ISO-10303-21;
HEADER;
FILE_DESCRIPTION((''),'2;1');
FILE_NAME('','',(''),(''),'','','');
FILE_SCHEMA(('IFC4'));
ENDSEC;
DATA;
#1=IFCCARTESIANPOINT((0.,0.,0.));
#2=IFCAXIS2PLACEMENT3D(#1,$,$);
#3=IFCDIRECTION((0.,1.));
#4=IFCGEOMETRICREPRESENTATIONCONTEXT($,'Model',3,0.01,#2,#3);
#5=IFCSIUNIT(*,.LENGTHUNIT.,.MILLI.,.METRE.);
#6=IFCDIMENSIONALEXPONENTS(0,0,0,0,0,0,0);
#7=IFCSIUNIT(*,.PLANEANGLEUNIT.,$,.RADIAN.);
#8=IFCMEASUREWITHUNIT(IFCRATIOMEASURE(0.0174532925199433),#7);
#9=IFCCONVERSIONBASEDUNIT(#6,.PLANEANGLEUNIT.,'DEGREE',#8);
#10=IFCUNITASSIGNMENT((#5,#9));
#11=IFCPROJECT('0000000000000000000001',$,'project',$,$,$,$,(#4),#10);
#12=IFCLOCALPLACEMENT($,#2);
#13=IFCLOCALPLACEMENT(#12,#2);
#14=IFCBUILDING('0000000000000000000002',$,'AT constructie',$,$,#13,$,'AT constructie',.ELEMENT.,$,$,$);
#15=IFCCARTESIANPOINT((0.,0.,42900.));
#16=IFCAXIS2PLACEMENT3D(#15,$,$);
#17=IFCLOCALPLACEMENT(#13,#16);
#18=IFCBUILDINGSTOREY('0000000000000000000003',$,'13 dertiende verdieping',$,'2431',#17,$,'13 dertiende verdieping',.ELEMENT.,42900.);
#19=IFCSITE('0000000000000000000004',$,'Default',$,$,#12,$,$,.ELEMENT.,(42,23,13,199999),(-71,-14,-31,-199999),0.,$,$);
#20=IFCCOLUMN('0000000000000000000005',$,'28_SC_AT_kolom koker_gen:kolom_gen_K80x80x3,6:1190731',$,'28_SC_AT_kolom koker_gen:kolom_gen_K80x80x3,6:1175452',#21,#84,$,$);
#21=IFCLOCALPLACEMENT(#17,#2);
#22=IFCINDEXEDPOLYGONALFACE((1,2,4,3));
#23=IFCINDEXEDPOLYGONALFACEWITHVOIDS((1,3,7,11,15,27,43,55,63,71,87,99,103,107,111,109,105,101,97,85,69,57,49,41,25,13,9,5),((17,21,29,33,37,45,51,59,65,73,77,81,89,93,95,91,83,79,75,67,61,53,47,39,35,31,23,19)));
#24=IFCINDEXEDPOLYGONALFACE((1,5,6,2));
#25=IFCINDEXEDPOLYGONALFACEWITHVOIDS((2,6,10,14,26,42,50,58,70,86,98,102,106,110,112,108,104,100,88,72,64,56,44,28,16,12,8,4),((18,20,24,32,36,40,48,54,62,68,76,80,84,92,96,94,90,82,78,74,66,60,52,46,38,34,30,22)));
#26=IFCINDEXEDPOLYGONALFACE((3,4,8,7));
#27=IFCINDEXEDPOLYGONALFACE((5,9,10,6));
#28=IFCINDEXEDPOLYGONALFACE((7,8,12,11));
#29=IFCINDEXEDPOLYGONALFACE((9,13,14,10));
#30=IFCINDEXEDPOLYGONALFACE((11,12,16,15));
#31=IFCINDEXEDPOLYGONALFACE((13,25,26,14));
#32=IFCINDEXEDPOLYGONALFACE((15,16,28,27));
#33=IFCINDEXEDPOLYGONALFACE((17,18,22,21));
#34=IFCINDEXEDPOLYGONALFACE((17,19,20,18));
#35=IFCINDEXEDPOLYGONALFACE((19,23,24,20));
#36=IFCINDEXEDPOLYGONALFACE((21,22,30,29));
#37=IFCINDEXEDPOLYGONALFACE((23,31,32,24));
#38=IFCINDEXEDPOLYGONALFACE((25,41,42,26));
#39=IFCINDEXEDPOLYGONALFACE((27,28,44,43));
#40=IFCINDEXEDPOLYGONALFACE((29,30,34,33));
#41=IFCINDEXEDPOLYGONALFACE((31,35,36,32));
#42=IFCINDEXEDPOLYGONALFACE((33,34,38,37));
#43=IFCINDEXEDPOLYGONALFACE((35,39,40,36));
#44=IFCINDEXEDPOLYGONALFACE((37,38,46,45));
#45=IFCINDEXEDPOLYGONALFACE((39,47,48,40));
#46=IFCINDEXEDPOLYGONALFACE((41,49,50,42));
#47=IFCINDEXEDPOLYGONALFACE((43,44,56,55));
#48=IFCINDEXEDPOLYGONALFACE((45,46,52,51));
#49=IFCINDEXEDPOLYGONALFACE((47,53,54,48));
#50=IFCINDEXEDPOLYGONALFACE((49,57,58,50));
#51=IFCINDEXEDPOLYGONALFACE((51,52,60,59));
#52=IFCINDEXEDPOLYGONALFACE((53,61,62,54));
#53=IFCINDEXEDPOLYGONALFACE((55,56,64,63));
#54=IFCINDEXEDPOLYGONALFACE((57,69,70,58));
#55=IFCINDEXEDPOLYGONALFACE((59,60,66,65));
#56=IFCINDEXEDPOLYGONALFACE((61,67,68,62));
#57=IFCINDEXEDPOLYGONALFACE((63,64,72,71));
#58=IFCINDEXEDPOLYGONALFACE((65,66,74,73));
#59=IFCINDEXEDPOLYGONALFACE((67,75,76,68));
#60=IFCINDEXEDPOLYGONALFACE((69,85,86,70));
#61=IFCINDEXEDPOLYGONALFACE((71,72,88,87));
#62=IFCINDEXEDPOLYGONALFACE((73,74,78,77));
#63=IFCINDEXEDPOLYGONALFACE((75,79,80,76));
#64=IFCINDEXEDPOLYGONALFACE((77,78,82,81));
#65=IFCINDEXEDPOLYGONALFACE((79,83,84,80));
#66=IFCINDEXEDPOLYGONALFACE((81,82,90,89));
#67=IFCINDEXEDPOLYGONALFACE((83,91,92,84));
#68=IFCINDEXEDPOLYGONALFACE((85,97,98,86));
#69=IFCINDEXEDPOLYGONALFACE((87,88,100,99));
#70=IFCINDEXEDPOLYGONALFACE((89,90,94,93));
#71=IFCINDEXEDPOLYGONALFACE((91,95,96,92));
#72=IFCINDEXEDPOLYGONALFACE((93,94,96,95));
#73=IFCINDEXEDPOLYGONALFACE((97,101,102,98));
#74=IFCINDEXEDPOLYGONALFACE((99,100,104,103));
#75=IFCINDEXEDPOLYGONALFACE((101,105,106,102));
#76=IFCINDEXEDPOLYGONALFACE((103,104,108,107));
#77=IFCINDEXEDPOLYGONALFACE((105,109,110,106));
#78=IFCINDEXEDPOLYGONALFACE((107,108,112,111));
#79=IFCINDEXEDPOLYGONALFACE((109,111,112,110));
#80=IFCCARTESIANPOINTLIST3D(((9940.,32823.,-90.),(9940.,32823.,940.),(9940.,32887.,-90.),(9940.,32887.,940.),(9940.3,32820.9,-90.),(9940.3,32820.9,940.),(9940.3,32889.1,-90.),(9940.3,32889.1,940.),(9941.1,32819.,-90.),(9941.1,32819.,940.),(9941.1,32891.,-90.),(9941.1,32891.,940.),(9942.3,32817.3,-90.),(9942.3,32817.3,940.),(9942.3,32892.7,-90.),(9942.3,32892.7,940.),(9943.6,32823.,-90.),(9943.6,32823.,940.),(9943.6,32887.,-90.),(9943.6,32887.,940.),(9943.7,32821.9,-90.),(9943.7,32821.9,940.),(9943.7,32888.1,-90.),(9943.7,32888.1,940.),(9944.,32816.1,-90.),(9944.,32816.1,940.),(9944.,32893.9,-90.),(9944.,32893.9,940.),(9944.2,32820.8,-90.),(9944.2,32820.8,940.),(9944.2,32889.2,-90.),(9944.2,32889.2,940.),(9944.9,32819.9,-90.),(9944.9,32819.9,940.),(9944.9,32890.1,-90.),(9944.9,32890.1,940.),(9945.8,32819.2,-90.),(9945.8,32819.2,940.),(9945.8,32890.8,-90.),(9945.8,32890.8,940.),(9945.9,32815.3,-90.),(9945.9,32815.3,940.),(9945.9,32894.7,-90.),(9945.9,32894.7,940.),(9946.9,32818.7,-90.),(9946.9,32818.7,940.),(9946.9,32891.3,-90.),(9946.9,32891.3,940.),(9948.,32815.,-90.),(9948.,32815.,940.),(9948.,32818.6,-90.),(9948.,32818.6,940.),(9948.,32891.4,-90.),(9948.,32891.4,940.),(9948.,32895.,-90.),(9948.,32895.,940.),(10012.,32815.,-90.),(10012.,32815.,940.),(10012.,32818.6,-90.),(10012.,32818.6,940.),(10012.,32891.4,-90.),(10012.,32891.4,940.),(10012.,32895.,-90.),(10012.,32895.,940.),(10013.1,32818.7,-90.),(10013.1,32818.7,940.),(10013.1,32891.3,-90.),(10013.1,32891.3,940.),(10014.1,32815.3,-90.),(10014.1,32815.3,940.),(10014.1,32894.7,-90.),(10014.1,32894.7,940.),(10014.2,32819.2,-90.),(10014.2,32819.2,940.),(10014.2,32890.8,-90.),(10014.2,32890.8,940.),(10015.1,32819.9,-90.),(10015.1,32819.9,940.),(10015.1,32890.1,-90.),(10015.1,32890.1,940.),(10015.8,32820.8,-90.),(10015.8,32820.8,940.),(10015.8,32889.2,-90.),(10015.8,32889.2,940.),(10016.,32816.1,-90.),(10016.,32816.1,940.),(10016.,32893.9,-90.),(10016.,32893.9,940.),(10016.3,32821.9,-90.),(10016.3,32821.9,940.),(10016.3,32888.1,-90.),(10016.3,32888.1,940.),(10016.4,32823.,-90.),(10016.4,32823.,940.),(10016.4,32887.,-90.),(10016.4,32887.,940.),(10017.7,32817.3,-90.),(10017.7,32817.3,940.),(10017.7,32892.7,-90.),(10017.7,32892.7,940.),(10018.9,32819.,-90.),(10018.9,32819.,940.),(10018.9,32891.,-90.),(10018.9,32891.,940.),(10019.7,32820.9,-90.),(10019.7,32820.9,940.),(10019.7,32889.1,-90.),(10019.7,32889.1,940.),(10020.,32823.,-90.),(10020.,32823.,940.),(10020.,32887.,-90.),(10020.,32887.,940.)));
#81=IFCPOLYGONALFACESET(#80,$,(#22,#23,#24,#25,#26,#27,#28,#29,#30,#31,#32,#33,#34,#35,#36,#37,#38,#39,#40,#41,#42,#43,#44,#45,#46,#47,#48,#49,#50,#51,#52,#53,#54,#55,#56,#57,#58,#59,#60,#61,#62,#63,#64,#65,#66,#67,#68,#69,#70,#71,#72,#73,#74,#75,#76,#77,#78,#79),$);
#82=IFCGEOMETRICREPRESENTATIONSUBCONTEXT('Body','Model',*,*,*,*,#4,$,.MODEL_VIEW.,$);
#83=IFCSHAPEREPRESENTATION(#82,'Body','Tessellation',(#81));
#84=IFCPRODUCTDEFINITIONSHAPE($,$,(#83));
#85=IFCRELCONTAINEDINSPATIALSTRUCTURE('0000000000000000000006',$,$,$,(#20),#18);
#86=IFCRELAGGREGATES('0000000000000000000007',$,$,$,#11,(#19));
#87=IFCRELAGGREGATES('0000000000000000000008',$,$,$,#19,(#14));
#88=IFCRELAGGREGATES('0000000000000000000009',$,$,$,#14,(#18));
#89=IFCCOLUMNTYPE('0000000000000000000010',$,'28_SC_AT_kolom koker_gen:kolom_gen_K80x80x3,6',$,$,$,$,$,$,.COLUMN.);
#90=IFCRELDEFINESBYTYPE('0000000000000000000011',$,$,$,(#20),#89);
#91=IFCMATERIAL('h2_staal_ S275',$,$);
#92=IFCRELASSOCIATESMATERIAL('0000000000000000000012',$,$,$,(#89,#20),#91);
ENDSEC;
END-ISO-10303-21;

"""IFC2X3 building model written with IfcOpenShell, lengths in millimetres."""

from ifc_helpers import new_model, entity, si_unit, converted_unit, direction, frame, frame_2d, origin, place, context, subcontext, project, spatial, polyline, circle_curve, parameter, trimmed, segment, composite_curve, outline, extrude, source, transform, mapped, material, type_object, type_shapes, element, save


model = new_model("IFC2X3")

# Units and contexts
model_context = context("Model", 3, precision=0.01, world=origin(), true_north=direction((0.0, 1.0)))
body_context = subcontext(model_context, "Body", "Model", "MODEL_VIEW")
ifc_project = project(units=[si_unit("LENGTHUNIT", "METRE", prefix="MILLI"), converted_unit("PLANEANGLEUNIT", "DEGREE", entity("IfcRatioMeasure", 0.0174532925199433), si_unit("PLANEANGLEUNIT", "RADIAN"), dimensions=[0, 0, 0, 0, 0, 0, 0])], contexts=[model_context])

# Site, building, storey
site_placement = place(None, origin())
site = spatial("IfcSite", under=ifc_project, at=site_placement, Name="Default", CompositionType="ELEMENT", RefLatitude=(42, 23, 13, 199999), RefLongitude=(-71, -14, -31, -199999), RefElevation=0.0)
building_placement = place(site_placement, origin())
building = spatial("IfcBuilding", under=site, at=building_placement, Name="AT constructie", LongName="AT constructie", CompositionType="ELEMENT")
storey_placement = place(building_placement, frame((0.0, 0.0, 42900.0)))
storey = spatial("IfcBuildingStorey", under=building, at=storey_placement, Name="13 dertiende verdieping", ObjectType="2431", LongName="13 dertiende verdieping", CompositionType="ELEMENT", Elevation=42900.0)

# Column
ifc_material = material(Name="h2_staal_ S275")
column_type_1 = type_object("IfcColumnType", Name="28_SC_AT_kolom koker_gen:kolom_gen_K80x80x3,6", PredefinedType="COLUMN", material=ifc_material)
shared_shape_1 = source(origin(), body_context, "Body", "SweptSolid", [
    extrude(outline(composite_curve([segment(trimmed(circle_curve(frame_2d((32.0, 32.0), x_axis=(1.0, 0.0)), 8.0), [parameter(360.0)], [parameter(90.0)], True, "PARAMETER"), True, "CONTINUOUS"), segment(polyline([(32.0, 40.0), (-32.0, 40.0)]), True, "CONTINUOUS"), segment(trimmed(circle_curve(frame_2d((-32.0, 32.0), x_axis=(1.0, 0.0)), 8.0), [parameter(90.0)], [parameter(180.0)], True, "PARAMETER"), True, "CONTINUOUS"), segment(polyline([(-40.0, 32.0), (-40.0, -32.0)]), True, "CONTINUOUS"), segment(trimmed(circle_curve(frame_2d((-32.0, -32.0), x_axis=(1.0, 0.0)), 8.0), [parameter(180.0)], [parameter(270.0)], True, "PARAMETER"), True, "CONTINUOUS"), segment(polyline([(-32.0, -40.0), (32.0, -40.0)]), True, "CONTINUOUS"), segment(trimmed(circle_curve(frame_2d((32.0, -32.0), x_axis=(1.0, 0.0)), 8.0), [parameter(270.0)], [parameter(0.0)], True, "PARAMETER"), True, "CONTINUOUS"), segment(polyline([(40.0, -32.0), (40.0, 32.0)]), True, "CONTINUOUS")], self_intersect=False), holes=[composite_curve([segment(polyline([(-32.0, 36.4), (32.0, 36.4)]), True, "CONTINUOUS"), segment(trimmed(circle_curve(frame_2d((32.0, 32.0), x_axis=(1.0, 0.0)), 4.4), [parameter(360.0)], [parameter(90.0)], True, "PARAMETER"), False, "CONTINUOUS"), segment(polyline([(36.4, 32.0), (36.4, -32.0)]), True, "CONTINUOUS"), segment(trimmed(circle_curve(frame_2d((32.0, -32.0), x_axis=(1.0, 0.0)), 4.4), [parameter(270.0)], [parameter(360.0)], True, "PARAMETER"), False, "CONTINUOUS"), segment(polyline([(32.0, -36.4), (-32.0, -36.4)]), True, "CONTINUOUS"), segment(trimmed(circle_curve(frame_2d((-32.0, -32.0), x_axis=(1.0, 0.0)), 4.4), [parameter(180.0)], [parameter(270.0)], True, "PARAMETER"), False, "CONTINUOUS"), segment(polyline([(-36.4, -32.0), (-36.4, 32.0)]), True, "CONTINUOUS"), segment(trimmed(circle_curve(frame_2d((-32.0, 32.0), x_axis=(1.0, 0.0)), 4.4), [parameter(90.0)], [parameter(180.0)], True, "PARAMETER"), False, "CONTINUOUS")], self_intersect=False)]), frame((0.0, 0.0, 42810.0), z_axis=(0.0, 0.0, 1.0), x_axis=(-1.0, 0.0, 0.0)), (0.0, 0.0, 1.0), 1030.0),
])
type_shapes(column_type_1, [shared_shape_1])
column_1_placement = place(storey_placement, frame((9980.0, 32855.0, -42900.0)))
element("IfcColumn", 1, at=column_1_placement, inside=storey, type_object=column_type_1, material=ifc_material, Name="28_SC_AT_kolom koker_gen:kolom_gen_K80x80x3,6:1190731", ObjectType="28_SC_AT_kolom koker_gen:kolom_gen_K80x80x3,6:1175452", context=body_context, shape_type="MappedRepresentation", body=[
    mapped(shared_shape_1, transform((0.0, 0.0, 0.0), scale=1.0)),
])

save(model, "model.ifc")
